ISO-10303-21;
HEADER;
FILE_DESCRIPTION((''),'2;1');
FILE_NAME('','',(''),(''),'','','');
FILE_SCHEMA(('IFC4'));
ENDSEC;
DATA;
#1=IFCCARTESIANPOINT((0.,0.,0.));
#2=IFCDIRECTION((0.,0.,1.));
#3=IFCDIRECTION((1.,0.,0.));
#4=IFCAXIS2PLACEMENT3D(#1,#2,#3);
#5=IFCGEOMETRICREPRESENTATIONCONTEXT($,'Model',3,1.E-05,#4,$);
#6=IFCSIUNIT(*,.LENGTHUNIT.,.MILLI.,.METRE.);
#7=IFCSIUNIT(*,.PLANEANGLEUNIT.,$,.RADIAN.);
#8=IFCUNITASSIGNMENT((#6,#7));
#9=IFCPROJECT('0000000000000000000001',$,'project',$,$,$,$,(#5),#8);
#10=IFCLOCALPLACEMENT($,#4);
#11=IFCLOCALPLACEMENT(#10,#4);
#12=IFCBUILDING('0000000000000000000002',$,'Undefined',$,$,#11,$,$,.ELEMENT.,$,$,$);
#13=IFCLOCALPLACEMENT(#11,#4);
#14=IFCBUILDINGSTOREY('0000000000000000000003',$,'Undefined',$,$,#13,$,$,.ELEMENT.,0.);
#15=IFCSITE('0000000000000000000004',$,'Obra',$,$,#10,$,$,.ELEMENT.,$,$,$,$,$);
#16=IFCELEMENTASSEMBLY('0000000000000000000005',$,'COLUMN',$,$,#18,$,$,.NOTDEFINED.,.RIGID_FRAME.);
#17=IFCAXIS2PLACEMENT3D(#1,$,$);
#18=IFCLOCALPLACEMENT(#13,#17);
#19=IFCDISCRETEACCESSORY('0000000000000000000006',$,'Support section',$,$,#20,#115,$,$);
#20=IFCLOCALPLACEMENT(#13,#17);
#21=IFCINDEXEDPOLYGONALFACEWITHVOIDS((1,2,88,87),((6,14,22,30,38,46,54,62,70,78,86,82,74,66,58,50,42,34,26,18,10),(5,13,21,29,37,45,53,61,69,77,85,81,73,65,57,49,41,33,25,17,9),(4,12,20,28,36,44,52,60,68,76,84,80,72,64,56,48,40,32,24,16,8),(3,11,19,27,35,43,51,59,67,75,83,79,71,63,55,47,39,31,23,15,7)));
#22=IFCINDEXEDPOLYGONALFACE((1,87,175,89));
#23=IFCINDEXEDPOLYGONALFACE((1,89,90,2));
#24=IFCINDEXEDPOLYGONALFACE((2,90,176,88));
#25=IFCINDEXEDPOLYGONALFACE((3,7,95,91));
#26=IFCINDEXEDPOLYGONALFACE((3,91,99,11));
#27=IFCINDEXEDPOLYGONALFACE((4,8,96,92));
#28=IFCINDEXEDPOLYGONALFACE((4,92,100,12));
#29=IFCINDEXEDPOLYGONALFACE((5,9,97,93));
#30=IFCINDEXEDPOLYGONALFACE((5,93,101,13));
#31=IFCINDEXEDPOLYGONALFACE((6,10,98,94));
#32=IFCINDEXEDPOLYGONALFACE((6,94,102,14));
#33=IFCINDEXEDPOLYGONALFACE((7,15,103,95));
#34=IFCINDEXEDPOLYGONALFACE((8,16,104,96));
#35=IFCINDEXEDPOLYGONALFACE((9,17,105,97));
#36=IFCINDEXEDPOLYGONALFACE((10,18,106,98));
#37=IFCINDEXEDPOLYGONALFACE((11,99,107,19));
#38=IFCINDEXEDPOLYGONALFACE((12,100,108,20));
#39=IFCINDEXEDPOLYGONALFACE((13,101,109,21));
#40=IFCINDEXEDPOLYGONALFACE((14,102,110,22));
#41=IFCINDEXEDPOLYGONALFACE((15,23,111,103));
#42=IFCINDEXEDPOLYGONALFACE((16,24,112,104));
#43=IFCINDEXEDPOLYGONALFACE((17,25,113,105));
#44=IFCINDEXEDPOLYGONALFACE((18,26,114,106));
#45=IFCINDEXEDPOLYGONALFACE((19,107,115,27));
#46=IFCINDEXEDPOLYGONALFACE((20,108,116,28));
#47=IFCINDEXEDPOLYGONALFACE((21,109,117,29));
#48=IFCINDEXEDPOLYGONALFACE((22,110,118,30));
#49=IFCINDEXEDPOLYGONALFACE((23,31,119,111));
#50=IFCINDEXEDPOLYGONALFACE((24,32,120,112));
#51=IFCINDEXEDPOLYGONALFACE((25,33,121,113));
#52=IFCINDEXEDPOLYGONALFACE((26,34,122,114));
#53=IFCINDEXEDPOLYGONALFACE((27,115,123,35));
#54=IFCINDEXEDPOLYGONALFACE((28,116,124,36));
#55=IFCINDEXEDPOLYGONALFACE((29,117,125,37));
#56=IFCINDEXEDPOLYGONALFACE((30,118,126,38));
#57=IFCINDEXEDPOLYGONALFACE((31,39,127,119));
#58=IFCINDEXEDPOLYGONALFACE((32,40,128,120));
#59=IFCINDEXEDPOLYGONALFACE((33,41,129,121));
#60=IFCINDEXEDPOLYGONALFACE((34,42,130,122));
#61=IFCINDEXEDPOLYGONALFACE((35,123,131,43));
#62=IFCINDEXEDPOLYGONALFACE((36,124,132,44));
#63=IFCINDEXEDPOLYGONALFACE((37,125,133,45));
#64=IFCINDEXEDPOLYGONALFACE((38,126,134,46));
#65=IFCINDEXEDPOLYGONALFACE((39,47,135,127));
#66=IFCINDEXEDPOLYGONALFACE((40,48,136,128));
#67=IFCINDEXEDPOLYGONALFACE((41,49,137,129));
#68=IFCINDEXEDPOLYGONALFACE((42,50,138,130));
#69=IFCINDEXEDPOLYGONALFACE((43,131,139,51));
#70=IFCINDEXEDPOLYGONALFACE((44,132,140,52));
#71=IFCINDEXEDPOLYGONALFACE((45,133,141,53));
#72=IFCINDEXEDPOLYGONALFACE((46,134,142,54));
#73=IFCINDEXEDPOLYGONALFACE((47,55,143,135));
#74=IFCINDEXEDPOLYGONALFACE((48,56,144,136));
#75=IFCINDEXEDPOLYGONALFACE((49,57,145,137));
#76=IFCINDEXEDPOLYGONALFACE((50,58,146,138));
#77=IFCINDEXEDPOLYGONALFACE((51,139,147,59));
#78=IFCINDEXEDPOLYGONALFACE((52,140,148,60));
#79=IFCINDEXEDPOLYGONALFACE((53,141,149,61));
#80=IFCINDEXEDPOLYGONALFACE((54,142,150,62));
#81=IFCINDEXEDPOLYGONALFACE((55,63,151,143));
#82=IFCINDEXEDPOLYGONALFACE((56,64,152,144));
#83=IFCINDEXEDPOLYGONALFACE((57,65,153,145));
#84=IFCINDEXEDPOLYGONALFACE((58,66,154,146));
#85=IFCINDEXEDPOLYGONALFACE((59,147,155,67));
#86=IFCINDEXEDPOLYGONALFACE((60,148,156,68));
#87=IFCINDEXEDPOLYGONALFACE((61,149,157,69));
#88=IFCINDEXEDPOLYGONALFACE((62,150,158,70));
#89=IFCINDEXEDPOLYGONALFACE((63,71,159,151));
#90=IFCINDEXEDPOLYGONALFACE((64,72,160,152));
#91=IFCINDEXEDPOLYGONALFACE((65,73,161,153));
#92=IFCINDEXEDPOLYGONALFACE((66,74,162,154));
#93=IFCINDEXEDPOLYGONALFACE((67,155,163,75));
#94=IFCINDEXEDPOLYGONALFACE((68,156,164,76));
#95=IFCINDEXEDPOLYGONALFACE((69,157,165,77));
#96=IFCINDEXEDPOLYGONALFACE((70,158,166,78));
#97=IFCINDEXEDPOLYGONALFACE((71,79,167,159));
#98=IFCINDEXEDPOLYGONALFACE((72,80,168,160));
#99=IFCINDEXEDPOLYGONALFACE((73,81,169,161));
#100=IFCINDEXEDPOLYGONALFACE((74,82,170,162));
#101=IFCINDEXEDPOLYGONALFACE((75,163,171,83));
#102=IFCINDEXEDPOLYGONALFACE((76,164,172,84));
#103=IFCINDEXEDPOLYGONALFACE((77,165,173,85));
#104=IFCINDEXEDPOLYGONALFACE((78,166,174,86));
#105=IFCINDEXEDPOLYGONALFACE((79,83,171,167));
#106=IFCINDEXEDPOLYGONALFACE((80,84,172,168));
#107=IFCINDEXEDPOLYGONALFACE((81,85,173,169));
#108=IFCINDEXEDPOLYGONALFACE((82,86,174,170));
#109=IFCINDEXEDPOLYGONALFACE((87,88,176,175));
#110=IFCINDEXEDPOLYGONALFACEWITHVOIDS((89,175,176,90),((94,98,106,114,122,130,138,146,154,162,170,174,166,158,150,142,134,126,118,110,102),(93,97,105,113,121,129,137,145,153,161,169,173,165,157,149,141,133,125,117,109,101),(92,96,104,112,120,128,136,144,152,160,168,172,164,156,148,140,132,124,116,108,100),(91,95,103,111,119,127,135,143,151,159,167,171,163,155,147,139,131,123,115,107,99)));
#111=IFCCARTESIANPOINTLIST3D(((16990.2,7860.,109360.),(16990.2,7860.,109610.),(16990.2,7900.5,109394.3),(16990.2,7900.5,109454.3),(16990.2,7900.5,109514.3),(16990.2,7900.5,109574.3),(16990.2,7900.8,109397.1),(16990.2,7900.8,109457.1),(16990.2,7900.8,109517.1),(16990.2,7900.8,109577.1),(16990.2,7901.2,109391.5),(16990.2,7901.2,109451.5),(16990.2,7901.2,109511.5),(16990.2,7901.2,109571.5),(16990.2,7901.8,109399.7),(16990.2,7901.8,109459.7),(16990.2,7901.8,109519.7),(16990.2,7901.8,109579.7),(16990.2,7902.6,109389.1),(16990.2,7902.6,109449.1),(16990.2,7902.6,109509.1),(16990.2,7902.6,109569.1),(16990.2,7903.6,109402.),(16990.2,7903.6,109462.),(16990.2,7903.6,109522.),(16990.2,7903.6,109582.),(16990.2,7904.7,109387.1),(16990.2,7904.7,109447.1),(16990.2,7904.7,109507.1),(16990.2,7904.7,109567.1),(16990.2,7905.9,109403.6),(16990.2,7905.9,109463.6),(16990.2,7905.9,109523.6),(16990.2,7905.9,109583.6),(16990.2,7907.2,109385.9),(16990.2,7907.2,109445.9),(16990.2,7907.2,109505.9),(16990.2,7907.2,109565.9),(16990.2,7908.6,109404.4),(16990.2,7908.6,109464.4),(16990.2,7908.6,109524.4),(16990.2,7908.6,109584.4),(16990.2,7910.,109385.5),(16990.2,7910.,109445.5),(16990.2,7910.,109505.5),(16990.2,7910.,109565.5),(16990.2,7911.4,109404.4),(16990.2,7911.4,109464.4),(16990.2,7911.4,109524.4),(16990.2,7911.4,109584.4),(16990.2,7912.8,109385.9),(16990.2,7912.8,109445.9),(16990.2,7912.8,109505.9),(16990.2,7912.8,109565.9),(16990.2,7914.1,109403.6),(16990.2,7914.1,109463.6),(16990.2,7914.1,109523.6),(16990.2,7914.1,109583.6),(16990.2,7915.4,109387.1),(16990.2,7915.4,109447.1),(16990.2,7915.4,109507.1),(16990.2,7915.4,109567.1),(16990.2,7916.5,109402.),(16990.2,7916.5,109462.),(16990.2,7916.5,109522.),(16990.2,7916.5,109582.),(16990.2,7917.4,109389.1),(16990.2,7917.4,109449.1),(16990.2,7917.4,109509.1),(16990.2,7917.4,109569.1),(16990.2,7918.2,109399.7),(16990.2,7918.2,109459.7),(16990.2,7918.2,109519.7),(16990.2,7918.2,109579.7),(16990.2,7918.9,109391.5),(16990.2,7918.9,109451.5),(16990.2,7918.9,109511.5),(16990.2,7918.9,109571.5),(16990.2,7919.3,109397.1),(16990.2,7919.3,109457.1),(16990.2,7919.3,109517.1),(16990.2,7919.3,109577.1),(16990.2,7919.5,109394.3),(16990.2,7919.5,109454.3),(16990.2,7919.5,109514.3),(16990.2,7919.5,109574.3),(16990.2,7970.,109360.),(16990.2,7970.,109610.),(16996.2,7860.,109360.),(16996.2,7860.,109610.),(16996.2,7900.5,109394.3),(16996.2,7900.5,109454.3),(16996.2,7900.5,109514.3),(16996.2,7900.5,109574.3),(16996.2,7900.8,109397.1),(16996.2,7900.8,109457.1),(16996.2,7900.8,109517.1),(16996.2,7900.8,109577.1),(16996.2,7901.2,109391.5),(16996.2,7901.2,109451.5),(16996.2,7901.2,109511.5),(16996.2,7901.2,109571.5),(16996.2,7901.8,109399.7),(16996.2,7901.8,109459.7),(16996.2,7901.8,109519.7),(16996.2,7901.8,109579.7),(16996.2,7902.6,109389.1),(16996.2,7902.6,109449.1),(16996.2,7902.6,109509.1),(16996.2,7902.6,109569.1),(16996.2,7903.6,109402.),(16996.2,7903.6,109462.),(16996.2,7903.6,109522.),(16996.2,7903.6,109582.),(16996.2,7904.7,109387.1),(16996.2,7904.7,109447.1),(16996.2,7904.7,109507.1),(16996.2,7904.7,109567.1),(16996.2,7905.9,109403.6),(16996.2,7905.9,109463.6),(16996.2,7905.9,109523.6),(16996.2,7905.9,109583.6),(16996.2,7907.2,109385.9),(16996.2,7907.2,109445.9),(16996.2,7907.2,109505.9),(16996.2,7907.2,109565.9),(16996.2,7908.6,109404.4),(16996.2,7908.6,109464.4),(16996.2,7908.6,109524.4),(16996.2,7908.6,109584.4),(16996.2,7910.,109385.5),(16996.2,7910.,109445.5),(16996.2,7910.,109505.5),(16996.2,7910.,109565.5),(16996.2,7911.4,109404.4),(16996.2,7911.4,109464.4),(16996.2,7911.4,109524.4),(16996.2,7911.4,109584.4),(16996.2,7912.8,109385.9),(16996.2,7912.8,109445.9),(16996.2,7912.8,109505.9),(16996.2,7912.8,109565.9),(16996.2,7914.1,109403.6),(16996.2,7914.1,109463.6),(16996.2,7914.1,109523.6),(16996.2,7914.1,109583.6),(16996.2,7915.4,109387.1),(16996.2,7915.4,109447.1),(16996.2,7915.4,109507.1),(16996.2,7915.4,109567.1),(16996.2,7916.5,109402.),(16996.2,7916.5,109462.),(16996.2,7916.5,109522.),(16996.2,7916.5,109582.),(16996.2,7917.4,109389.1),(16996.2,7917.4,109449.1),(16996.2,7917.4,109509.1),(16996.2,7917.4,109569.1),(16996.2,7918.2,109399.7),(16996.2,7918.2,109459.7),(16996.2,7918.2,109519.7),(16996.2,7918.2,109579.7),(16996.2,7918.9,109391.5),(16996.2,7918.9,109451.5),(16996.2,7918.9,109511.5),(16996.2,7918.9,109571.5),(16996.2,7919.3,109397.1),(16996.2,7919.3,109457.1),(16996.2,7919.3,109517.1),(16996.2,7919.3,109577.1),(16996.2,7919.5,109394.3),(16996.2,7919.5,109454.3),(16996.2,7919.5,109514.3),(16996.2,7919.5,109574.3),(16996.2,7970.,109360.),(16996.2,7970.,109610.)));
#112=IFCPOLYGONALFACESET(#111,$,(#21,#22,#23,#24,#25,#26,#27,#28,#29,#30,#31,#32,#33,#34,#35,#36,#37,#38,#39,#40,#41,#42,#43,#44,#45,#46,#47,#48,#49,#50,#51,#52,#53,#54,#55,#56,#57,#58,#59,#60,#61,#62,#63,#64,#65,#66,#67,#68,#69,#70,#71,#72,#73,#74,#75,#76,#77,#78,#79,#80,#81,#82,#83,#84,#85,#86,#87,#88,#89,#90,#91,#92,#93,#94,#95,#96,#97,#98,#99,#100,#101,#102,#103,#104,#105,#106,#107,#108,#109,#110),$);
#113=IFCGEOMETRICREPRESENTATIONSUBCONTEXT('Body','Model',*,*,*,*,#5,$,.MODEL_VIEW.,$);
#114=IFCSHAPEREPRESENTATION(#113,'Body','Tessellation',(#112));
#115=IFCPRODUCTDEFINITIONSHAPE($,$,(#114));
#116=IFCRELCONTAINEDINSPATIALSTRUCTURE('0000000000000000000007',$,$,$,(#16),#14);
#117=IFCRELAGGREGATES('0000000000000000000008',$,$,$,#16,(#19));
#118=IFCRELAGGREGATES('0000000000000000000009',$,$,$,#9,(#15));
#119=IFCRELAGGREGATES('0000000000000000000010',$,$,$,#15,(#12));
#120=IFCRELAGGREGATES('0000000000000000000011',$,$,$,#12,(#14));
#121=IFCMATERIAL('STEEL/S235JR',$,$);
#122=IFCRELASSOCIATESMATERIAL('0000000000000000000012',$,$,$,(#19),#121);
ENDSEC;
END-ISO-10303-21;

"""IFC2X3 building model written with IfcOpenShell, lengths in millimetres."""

from ifc_helpers import new_model, si_unit, frame, origin_with_axes, origin_2d_with_axis, place, context, subcontext, project, spatial, rectangle, circle, extrude, source, transform, mapped, material, element, aggregate, save


model = new_model("IFC2X3")

# Units and contexts
model_context = context("Model", 3, precision=1e-05, world=origin_with_axes())
body_context = subcontext(model_context, "Body", "Model", "MODEL_VIEW")
ifc_project = project(units=[si_unit("LENGTHUNIT", "METRE", prefix="MILLI"), si_unit("PLANEANGLEUNIT", "RADIAN")], contexts=[model_context])

# Site, building, storey
site_placement = place(None, origin_with_axes())
site = spatial("IfcSite", under=ifc_project, at=site_placement, Name="Obra", CompositionType="ELEMENT")
building_placement = place(site_placement, origin_with_axes())
building = spatial("IfcBuilding", under=site, at=building_placement, Name="Undefined", CompositionType="ELEMENT")
storey_placement = place(building_placement, origin_with_axes())
storey = spatial("IfcBuildingStorey", under=building, at=storey_placement, Name="Undefined", CompositionType="ELEMENT", Elevation=0.0)

# Element assembly
assembly_1_placement = place(storey_placement, origin_with_axes())
assembly_1 = element("IfcElementAssembly", 1, at=assembly_1_placement, inside=storey, Name="COLUMN", AssemblyPlace="NOTDEFINED", PredefinedType="RIGID_FRAME")
ifc_material_1 = material(Name="STEEL/S235JR")

# Shared definitions
shared_shape_1 = source(origin_with_axes(), body_context, "Body", "SweptSolid", [
    extrude(circle(Radius=9.5, at=origin_2d_with_axis()), frame((0.0, -9.9, 0.0), z_axis=(0.0, 1.0, 0.0), x_axis=(1.0, 0.0, 0.0)), (0.0, 0.0, 1.0), 6.2),
])

# Discrete accessory, opening
discrete_accessory_1_placement = place(assembly_1_placement, frame((16993.2, 7915.0, 109360.0), z_axis=(0.0, 0.0, 1.0), x_axis=(0.0, 1.0, 0.0)))
discrete_accessory_1 = element("IfcDiscreteAccessory", 2, at=discrete_accessory_1_placement, material=ifc_material_1, Name="Support section", context=body_context, shape_type="SweptSolid", body=[
    extrude(rectangle(XDim=6.0, YDim=110.0, at=origin_2d_with_axis()), frame((0.0, 0.0, 250.0), z_axis=(0.0, 0.0, -1.0), x_axis=(0.0, 1.0, 0.0)), (0.0, 0.0, 1.0), 250.0),
])
opening_1_placement = place(assembly_1_placement, frame((17000.0, 7960.0, 109650.0), z_axis=(0.0, -1.0, 0.0), x_axis=(0.0, 0.0, -1.0)))
element("IfcOpeningElement", 3, at=opening_1_placement, cuts=discrete_accessory_1, ObjectType="Opening", context=body_context, shape_type="MappedRepresentation", body=[
    mapped(shared_shape_1, transform((75.0, 0.0, 50.0))),
    mapped(shared_shape_1, transform((135.0, 0.0, 50.0))),
    mapped(shared_shape_1, transform((195.0, 0.0, 50.0))),
    mapped(shared_shape_1, transform((255.0, 0.0, 50.0))),
])
aggregate(assembly_1, [discrete_accessory_1])

save(model, "model.ifc")
